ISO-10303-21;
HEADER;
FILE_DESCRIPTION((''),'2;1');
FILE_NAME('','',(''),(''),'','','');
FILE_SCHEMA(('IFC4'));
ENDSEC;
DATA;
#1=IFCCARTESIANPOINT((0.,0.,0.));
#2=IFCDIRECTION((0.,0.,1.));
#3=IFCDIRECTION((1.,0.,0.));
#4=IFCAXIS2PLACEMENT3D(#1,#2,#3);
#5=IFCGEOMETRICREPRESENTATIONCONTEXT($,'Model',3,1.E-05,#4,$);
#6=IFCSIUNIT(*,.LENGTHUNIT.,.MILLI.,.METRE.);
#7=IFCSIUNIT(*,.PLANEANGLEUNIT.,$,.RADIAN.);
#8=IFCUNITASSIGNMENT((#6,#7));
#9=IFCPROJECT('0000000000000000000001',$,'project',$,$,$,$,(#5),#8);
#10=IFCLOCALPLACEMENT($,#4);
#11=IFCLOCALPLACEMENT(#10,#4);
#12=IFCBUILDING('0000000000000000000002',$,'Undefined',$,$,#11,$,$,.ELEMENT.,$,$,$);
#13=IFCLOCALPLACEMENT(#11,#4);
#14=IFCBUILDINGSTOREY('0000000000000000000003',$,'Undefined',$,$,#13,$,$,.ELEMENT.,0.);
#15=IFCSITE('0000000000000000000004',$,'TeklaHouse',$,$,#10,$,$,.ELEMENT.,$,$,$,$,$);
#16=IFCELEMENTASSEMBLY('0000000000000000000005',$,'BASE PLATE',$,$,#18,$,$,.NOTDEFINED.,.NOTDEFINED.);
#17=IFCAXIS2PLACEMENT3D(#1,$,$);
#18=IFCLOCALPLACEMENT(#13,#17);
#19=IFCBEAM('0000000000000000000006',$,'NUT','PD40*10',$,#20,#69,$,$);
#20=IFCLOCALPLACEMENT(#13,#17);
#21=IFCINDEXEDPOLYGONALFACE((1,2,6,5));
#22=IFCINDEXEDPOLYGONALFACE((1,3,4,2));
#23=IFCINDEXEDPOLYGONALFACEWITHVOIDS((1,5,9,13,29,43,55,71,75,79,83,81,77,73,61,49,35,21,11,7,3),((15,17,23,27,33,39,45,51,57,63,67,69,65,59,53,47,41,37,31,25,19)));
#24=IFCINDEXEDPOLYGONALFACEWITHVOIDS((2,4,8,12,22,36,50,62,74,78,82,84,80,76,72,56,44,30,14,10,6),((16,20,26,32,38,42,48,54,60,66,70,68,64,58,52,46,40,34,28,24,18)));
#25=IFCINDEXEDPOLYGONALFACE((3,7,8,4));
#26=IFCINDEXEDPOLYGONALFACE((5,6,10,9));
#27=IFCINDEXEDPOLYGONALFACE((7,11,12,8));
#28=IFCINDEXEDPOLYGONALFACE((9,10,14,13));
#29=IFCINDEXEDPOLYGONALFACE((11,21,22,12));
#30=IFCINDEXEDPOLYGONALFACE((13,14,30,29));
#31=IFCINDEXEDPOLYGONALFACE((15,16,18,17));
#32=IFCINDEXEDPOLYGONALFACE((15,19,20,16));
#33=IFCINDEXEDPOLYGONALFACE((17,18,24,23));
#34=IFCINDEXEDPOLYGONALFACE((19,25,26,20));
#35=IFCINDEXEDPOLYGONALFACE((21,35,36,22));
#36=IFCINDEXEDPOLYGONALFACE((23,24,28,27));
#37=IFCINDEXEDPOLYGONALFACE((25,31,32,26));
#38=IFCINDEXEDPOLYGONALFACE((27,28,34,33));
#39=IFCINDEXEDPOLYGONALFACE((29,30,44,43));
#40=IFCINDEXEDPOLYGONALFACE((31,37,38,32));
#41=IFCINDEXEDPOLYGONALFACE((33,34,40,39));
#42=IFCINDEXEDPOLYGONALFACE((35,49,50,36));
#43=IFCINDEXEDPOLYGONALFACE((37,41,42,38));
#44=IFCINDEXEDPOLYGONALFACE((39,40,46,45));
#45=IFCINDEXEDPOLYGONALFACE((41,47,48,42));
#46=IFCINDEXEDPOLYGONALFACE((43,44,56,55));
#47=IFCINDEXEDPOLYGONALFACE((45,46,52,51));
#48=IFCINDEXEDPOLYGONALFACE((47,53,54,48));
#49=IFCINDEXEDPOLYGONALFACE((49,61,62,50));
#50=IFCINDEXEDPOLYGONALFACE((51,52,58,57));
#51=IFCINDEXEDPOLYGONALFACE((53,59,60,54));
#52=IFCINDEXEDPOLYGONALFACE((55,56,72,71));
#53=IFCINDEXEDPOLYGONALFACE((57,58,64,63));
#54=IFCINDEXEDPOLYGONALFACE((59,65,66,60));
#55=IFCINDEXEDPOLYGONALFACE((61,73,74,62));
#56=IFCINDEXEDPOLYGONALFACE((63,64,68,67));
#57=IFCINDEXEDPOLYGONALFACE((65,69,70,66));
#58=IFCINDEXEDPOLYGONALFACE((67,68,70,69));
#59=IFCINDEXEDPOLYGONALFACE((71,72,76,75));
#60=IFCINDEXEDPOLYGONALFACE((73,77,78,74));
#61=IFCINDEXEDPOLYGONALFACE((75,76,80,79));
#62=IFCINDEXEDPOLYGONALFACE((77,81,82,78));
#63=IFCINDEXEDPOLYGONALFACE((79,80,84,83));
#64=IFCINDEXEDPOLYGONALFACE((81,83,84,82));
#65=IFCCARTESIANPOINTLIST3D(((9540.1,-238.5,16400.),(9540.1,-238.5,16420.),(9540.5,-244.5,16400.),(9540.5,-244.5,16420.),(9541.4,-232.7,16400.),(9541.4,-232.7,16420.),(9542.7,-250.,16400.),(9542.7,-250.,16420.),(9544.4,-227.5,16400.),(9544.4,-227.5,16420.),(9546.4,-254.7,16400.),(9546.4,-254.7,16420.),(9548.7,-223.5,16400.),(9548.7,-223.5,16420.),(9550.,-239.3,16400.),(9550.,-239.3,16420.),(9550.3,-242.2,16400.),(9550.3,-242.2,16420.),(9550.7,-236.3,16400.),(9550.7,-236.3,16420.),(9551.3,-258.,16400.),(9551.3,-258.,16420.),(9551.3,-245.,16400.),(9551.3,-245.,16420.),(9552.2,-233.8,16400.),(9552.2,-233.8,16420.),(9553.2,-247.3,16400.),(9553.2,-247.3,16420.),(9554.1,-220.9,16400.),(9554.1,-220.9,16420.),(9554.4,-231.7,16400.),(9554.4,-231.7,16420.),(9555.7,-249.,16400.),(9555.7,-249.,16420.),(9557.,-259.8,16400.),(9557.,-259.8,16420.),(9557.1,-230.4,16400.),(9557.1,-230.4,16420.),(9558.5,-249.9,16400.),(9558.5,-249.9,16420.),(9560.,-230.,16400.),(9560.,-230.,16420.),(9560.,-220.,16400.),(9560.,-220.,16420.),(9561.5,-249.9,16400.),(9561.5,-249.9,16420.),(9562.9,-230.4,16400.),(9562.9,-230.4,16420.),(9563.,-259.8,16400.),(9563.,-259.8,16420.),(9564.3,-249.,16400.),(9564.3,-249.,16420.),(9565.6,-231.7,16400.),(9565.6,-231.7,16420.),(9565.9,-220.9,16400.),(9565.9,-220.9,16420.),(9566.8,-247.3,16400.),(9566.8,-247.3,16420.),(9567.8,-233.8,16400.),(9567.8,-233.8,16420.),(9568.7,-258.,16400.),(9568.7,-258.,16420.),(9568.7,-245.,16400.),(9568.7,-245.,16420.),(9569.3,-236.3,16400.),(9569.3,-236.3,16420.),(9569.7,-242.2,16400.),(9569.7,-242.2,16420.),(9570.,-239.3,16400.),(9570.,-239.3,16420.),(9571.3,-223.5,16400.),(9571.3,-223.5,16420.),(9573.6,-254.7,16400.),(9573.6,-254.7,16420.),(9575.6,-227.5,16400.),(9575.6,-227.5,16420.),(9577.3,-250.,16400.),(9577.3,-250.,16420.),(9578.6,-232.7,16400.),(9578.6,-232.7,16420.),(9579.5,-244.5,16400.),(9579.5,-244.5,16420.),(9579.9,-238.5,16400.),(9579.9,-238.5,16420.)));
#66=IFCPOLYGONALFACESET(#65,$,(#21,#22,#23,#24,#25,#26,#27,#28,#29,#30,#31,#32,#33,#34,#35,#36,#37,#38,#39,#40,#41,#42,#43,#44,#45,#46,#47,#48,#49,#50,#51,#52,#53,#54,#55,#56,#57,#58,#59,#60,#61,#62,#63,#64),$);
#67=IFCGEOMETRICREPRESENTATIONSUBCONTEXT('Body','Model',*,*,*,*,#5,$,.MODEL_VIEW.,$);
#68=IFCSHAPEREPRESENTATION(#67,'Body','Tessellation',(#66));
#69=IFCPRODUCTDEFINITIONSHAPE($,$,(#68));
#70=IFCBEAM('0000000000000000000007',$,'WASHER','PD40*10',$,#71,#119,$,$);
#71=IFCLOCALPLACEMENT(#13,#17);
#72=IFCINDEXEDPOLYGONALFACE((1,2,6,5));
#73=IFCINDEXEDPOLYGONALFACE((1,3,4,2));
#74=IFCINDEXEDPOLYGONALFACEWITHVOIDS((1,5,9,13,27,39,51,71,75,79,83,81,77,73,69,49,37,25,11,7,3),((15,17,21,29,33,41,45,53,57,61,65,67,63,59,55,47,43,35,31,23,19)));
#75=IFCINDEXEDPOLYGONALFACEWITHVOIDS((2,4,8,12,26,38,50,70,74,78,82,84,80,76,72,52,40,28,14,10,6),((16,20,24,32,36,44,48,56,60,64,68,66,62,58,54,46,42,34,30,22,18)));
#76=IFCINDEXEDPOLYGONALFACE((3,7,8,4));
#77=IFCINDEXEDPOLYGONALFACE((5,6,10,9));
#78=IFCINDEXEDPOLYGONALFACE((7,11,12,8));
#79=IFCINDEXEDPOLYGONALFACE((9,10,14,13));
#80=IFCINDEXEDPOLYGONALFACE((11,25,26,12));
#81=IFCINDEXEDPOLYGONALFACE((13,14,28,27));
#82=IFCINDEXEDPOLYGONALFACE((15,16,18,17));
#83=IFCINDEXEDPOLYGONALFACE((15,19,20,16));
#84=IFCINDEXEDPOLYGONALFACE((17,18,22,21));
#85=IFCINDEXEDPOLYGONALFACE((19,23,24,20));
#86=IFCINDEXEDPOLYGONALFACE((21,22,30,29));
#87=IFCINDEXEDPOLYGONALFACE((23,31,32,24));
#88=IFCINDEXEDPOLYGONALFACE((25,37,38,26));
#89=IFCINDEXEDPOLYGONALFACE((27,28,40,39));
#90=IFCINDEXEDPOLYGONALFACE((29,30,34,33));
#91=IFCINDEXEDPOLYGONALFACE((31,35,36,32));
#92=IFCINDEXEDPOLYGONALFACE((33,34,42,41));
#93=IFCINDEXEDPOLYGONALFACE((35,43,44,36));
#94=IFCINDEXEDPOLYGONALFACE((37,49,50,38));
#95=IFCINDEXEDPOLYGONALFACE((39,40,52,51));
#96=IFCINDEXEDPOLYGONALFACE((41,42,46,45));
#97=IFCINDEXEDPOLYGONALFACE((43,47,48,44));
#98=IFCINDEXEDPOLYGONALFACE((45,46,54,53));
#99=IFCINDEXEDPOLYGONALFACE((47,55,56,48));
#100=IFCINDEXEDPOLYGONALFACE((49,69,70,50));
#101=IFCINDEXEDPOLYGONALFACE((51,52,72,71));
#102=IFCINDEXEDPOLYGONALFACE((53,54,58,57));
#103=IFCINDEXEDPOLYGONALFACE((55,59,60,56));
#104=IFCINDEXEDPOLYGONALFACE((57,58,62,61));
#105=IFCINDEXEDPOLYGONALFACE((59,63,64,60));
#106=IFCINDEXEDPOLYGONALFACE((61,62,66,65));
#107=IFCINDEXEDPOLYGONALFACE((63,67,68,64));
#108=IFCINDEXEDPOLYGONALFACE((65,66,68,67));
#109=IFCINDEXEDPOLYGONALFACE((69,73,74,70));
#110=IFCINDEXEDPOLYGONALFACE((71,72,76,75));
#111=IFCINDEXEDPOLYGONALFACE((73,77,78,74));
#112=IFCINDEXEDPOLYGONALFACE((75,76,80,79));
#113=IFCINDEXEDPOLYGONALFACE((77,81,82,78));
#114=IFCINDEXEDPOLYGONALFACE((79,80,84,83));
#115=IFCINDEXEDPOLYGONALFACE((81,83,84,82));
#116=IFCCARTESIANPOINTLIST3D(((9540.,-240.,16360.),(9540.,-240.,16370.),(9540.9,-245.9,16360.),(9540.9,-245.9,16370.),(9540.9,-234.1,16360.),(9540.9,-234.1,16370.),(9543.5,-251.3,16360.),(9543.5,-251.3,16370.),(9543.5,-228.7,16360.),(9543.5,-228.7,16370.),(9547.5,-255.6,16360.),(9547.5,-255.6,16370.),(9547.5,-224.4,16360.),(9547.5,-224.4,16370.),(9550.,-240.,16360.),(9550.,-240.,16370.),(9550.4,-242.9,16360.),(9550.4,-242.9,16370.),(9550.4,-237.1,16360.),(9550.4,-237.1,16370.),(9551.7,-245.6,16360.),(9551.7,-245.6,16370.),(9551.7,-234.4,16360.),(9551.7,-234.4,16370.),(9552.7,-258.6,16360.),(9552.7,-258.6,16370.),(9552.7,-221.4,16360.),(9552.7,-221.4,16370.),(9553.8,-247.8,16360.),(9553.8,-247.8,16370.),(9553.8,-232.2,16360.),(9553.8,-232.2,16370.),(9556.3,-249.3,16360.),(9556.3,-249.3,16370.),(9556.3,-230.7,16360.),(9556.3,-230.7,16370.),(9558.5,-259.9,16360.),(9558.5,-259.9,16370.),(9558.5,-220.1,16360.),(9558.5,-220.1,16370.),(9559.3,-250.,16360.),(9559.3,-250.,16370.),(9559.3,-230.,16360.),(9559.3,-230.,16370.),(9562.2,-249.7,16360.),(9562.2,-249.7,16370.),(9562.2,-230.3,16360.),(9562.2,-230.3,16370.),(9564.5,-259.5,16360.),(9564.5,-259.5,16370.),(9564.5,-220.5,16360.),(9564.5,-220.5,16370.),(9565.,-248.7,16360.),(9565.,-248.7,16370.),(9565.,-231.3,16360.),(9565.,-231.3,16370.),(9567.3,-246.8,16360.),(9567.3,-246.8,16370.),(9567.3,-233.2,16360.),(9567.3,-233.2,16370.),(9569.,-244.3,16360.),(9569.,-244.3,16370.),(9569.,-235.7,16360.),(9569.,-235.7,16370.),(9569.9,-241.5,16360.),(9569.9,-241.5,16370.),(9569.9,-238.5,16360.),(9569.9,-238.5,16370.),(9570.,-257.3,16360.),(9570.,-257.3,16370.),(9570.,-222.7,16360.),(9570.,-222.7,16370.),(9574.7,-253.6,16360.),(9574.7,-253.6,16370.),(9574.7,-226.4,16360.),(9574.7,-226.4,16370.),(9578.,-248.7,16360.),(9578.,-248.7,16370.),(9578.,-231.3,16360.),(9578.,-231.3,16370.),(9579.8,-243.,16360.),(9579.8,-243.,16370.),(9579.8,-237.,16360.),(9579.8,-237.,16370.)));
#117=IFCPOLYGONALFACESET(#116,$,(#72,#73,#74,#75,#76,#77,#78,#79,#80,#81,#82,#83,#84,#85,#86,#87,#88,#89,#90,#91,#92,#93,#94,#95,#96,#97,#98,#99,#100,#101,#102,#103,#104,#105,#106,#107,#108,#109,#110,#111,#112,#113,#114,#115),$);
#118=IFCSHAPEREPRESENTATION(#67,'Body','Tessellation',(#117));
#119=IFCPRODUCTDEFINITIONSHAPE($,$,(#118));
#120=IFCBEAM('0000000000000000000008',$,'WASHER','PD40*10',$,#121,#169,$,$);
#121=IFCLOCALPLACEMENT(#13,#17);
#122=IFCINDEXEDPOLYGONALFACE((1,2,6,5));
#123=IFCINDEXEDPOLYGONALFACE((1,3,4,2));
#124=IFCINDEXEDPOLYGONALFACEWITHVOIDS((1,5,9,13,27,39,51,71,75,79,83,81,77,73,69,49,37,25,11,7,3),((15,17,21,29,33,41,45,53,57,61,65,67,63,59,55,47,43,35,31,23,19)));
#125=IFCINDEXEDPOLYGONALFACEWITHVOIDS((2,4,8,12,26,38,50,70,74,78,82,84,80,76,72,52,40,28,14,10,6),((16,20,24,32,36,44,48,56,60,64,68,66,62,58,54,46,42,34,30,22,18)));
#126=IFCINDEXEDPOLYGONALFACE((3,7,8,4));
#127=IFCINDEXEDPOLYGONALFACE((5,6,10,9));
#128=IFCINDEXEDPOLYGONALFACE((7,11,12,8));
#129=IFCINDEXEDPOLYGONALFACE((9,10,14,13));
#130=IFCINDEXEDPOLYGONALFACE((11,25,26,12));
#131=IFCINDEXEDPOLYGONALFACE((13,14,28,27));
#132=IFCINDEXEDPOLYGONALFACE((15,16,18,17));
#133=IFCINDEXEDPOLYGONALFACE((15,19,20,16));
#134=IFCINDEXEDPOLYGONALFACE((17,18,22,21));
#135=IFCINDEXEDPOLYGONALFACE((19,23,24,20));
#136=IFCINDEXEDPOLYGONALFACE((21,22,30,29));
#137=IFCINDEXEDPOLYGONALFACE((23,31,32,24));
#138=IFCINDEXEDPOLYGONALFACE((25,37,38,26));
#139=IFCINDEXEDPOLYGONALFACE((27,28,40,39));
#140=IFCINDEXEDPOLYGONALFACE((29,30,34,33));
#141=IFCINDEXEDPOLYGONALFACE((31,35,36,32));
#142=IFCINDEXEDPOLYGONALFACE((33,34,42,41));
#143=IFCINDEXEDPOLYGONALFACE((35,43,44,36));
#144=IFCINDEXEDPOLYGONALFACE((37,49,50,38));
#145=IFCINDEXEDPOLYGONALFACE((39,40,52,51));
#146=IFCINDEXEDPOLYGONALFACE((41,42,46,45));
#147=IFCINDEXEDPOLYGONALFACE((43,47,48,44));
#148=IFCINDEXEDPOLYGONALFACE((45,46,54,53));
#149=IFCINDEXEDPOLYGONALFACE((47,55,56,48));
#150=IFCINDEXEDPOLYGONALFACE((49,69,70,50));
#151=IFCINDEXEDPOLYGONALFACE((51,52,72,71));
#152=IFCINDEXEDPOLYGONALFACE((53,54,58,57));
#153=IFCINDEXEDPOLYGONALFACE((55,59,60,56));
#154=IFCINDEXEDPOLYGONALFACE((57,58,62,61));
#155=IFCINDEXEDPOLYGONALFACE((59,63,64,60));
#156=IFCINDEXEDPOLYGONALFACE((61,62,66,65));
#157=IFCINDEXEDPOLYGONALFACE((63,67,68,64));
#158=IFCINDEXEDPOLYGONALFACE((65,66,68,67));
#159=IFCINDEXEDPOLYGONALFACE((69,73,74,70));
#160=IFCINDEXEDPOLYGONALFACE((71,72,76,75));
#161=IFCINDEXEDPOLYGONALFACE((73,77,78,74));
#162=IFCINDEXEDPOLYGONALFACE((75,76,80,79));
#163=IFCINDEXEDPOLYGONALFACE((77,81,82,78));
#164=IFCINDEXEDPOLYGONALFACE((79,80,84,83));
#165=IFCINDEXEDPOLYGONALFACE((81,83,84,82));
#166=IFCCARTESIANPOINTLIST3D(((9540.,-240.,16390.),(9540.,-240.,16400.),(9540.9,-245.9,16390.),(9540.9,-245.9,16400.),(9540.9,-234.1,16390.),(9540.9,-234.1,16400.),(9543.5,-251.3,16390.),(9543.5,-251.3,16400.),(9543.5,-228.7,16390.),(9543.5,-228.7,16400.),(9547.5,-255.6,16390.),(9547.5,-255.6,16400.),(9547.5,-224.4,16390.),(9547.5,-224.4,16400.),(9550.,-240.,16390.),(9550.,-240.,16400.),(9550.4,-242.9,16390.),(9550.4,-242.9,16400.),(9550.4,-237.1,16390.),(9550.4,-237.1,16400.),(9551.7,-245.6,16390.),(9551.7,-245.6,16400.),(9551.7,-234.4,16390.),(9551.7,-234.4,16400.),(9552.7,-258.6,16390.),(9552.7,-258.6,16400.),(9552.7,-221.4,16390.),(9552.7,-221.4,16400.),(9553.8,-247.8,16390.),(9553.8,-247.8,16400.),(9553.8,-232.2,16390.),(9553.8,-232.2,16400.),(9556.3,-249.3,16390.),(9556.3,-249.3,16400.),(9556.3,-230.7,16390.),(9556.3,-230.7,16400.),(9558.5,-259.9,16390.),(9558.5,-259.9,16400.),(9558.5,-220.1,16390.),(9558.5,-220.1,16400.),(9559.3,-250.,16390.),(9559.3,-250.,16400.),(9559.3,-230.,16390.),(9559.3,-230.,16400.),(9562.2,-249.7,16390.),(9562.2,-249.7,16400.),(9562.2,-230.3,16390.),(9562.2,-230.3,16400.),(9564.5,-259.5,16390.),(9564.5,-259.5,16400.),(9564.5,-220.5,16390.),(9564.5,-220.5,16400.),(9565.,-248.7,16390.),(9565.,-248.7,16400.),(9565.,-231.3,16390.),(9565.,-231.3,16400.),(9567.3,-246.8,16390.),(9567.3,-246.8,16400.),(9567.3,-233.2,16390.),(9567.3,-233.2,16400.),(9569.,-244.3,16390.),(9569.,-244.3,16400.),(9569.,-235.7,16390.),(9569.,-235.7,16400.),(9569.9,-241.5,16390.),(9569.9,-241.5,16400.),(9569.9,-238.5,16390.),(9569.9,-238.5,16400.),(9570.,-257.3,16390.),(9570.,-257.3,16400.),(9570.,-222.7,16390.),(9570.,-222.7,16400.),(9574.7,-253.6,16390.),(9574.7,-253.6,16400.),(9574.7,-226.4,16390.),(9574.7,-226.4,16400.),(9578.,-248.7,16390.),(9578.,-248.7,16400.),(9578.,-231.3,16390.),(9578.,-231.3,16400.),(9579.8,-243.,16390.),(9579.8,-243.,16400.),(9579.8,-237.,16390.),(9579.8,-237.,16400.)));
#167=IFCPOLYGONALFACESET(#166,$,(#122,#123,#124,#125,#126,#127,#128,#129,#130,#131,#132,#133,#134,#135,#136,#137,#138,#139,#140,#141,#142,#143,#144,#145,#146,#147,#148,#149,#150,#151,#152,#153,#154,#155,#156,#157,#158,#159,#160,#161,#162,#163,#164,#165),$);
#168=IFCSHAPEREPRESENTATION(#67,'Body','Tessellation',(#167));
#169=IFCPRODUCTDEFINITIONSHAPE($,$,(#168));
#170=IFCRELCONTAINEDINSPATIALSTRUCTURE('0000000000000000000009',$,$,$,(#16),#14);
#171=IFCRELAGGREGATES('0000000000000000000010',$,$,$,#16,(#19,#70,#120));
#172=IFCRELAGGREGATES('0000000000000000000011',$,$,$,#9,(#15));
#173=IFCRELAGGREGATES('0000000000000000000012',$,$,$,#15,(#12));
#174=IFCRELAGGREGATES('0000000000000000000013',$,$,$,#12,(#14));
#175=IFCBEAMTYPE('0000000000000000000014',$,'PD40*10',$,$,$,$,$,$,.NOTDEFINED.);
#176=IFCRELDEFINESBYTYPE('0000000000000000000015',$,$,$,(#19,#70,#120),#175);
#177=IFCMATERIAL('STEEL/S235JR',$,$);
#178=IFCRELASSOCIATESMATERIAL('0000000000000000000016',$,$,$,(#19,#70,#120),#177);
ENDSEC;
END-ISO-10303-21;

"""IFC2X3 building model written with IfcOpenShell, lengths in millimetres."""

from ifc_helpers import new_model, si_unit, frame, origin_with_axes, origin_2d_with_axis, place, context, subcontext, project, spatial, hollow_circle, extrude, material, type_object, element, aggregate, save


model = new_model("IFC2X3")

# Units and contexts
model_context = context("Model", 3, precision=1e-05, world=origin_with_axes())
body_context = subcontext(model_context, "Body", "Model", "MODEL_VIEW")
ifc_project = project(units=[si_unit("LENGTHUNIT", "METRE", prefix="MILLI"), si_unit("PLANEANGLEUNIT", "RADIAN")], contexts=[model_context])

# Site, building, storey
site_placement = place(None, origin_with_axes())
site = spatial("IfcSite", under=ifc_project, at=site_placement, Name="TeklaHouse", CompositionType="ELEMENT")
building_placement = place(site_placement, origin_with_axes())
building = spatial("IfcBuilding", under=site, at=building_placement, Name="Undefined", CompositionType="ELEMENT")
storey_placement = place(building_placement, origin_with_axes())
storey = spatial("IfcBuildingStorey", under=building, at=storey_placement, Name="Undefined", CompositionType="ELEMENT", Elevation=0.0)

# Element assembly, beams
assembly_1_placement = place(storey_placement, origin_with_axes())
assembly_1 = element("IfcElementAssembly", 1, at=assembly_1_placement, inside=storey, Name="BASE PLATE", AssemblyPlace="NOTDEFINED", PredefinedType="NOTDEFINED")
ifc_material_1 = material(Name="STEEL/S235JR")
beam_type_1 = type_object("IfcBeamType", Name="PD40*10", PredefinedType="NOTDEFINED")
beam_1_placement = place(assembly_1_placement, frame((9560.0, -240.0, 16420.0), z_axis=(-1.0, 0.0, 0.0), x_axis=(0.0, 0.0, -1.0)))
beam_1 = element("IfcBeam", 2, at=beam_1_placement, type_object=beam_type_1, material=ifc_material_1, Name="NUT", Description="PD40*10", context=body_context, shape_type="SweptSolid", body=[
    extrude(hollow_circle(Radius=20.0, WallThickness=10.0, at=origin_2d_with_axis()), frame((20.0, 0.0, 0.0), z_axis=(-1.0, 0.0, 0.0), x_axis=(0.0, -1.0, 0.0)), (0.0, 0.0, 1.0), 20.0),
])
beam_2_placement = place(assembly_1_placement, frame((9560.0, -240.0, 16370.0), z_axis=(0.0, -1.0, 0.0), x_axis=(0.0, 0.0, -1.0)))
beam_2 = element("IfcBeam", 3, at=beam_2_placement, type_object=beam_type_1, material=ifc_material_1, Name="WASHER", Description="PD40*10", context=body_context, shape_type="SweptSolid", body=[
    extrude(hollow_circle(Radius=20.0, WallThickness=10.0, at=origin_2d_with_axis()), frame((10.0, 0.0, 0.0), z_axis=(-1.0, 0.0, 0.0), x_axis=(0.0, -1.0, 0.0)), (0.0, 0.0, 1.0), 10.0),
])
beam_3_placement = place(assembly_1_placement, frame((9560.0, -240.0, 16400.0), z_axis=(0.0, -1.0, 0.0), x_axis=(0.0, 0.0, -1.0)))
beam_3 = element("IfcBeam", 4, at=beam_3_placement, type_object=beam_type_1, material=ifc_material_1, Name="WASHER", Description="PD40*10", context=body_context, shape_type="SweptSolid", body=[
    extrude(hollow_circle(Radius=20.0, WallThickness=10.0, at=origin_2d_with_axis()), frame((10.0, 0.0, 0.0), z_axis=(-1.0, 0.0, 0.0), x_axis=(0.0, -1.0, 0.0)), (0.0, 0.0, 1.0), 10.0),
])

aggregate(assembly_1, [beam_1, beam_2, beam_3])

save(model, "model.ifc")
